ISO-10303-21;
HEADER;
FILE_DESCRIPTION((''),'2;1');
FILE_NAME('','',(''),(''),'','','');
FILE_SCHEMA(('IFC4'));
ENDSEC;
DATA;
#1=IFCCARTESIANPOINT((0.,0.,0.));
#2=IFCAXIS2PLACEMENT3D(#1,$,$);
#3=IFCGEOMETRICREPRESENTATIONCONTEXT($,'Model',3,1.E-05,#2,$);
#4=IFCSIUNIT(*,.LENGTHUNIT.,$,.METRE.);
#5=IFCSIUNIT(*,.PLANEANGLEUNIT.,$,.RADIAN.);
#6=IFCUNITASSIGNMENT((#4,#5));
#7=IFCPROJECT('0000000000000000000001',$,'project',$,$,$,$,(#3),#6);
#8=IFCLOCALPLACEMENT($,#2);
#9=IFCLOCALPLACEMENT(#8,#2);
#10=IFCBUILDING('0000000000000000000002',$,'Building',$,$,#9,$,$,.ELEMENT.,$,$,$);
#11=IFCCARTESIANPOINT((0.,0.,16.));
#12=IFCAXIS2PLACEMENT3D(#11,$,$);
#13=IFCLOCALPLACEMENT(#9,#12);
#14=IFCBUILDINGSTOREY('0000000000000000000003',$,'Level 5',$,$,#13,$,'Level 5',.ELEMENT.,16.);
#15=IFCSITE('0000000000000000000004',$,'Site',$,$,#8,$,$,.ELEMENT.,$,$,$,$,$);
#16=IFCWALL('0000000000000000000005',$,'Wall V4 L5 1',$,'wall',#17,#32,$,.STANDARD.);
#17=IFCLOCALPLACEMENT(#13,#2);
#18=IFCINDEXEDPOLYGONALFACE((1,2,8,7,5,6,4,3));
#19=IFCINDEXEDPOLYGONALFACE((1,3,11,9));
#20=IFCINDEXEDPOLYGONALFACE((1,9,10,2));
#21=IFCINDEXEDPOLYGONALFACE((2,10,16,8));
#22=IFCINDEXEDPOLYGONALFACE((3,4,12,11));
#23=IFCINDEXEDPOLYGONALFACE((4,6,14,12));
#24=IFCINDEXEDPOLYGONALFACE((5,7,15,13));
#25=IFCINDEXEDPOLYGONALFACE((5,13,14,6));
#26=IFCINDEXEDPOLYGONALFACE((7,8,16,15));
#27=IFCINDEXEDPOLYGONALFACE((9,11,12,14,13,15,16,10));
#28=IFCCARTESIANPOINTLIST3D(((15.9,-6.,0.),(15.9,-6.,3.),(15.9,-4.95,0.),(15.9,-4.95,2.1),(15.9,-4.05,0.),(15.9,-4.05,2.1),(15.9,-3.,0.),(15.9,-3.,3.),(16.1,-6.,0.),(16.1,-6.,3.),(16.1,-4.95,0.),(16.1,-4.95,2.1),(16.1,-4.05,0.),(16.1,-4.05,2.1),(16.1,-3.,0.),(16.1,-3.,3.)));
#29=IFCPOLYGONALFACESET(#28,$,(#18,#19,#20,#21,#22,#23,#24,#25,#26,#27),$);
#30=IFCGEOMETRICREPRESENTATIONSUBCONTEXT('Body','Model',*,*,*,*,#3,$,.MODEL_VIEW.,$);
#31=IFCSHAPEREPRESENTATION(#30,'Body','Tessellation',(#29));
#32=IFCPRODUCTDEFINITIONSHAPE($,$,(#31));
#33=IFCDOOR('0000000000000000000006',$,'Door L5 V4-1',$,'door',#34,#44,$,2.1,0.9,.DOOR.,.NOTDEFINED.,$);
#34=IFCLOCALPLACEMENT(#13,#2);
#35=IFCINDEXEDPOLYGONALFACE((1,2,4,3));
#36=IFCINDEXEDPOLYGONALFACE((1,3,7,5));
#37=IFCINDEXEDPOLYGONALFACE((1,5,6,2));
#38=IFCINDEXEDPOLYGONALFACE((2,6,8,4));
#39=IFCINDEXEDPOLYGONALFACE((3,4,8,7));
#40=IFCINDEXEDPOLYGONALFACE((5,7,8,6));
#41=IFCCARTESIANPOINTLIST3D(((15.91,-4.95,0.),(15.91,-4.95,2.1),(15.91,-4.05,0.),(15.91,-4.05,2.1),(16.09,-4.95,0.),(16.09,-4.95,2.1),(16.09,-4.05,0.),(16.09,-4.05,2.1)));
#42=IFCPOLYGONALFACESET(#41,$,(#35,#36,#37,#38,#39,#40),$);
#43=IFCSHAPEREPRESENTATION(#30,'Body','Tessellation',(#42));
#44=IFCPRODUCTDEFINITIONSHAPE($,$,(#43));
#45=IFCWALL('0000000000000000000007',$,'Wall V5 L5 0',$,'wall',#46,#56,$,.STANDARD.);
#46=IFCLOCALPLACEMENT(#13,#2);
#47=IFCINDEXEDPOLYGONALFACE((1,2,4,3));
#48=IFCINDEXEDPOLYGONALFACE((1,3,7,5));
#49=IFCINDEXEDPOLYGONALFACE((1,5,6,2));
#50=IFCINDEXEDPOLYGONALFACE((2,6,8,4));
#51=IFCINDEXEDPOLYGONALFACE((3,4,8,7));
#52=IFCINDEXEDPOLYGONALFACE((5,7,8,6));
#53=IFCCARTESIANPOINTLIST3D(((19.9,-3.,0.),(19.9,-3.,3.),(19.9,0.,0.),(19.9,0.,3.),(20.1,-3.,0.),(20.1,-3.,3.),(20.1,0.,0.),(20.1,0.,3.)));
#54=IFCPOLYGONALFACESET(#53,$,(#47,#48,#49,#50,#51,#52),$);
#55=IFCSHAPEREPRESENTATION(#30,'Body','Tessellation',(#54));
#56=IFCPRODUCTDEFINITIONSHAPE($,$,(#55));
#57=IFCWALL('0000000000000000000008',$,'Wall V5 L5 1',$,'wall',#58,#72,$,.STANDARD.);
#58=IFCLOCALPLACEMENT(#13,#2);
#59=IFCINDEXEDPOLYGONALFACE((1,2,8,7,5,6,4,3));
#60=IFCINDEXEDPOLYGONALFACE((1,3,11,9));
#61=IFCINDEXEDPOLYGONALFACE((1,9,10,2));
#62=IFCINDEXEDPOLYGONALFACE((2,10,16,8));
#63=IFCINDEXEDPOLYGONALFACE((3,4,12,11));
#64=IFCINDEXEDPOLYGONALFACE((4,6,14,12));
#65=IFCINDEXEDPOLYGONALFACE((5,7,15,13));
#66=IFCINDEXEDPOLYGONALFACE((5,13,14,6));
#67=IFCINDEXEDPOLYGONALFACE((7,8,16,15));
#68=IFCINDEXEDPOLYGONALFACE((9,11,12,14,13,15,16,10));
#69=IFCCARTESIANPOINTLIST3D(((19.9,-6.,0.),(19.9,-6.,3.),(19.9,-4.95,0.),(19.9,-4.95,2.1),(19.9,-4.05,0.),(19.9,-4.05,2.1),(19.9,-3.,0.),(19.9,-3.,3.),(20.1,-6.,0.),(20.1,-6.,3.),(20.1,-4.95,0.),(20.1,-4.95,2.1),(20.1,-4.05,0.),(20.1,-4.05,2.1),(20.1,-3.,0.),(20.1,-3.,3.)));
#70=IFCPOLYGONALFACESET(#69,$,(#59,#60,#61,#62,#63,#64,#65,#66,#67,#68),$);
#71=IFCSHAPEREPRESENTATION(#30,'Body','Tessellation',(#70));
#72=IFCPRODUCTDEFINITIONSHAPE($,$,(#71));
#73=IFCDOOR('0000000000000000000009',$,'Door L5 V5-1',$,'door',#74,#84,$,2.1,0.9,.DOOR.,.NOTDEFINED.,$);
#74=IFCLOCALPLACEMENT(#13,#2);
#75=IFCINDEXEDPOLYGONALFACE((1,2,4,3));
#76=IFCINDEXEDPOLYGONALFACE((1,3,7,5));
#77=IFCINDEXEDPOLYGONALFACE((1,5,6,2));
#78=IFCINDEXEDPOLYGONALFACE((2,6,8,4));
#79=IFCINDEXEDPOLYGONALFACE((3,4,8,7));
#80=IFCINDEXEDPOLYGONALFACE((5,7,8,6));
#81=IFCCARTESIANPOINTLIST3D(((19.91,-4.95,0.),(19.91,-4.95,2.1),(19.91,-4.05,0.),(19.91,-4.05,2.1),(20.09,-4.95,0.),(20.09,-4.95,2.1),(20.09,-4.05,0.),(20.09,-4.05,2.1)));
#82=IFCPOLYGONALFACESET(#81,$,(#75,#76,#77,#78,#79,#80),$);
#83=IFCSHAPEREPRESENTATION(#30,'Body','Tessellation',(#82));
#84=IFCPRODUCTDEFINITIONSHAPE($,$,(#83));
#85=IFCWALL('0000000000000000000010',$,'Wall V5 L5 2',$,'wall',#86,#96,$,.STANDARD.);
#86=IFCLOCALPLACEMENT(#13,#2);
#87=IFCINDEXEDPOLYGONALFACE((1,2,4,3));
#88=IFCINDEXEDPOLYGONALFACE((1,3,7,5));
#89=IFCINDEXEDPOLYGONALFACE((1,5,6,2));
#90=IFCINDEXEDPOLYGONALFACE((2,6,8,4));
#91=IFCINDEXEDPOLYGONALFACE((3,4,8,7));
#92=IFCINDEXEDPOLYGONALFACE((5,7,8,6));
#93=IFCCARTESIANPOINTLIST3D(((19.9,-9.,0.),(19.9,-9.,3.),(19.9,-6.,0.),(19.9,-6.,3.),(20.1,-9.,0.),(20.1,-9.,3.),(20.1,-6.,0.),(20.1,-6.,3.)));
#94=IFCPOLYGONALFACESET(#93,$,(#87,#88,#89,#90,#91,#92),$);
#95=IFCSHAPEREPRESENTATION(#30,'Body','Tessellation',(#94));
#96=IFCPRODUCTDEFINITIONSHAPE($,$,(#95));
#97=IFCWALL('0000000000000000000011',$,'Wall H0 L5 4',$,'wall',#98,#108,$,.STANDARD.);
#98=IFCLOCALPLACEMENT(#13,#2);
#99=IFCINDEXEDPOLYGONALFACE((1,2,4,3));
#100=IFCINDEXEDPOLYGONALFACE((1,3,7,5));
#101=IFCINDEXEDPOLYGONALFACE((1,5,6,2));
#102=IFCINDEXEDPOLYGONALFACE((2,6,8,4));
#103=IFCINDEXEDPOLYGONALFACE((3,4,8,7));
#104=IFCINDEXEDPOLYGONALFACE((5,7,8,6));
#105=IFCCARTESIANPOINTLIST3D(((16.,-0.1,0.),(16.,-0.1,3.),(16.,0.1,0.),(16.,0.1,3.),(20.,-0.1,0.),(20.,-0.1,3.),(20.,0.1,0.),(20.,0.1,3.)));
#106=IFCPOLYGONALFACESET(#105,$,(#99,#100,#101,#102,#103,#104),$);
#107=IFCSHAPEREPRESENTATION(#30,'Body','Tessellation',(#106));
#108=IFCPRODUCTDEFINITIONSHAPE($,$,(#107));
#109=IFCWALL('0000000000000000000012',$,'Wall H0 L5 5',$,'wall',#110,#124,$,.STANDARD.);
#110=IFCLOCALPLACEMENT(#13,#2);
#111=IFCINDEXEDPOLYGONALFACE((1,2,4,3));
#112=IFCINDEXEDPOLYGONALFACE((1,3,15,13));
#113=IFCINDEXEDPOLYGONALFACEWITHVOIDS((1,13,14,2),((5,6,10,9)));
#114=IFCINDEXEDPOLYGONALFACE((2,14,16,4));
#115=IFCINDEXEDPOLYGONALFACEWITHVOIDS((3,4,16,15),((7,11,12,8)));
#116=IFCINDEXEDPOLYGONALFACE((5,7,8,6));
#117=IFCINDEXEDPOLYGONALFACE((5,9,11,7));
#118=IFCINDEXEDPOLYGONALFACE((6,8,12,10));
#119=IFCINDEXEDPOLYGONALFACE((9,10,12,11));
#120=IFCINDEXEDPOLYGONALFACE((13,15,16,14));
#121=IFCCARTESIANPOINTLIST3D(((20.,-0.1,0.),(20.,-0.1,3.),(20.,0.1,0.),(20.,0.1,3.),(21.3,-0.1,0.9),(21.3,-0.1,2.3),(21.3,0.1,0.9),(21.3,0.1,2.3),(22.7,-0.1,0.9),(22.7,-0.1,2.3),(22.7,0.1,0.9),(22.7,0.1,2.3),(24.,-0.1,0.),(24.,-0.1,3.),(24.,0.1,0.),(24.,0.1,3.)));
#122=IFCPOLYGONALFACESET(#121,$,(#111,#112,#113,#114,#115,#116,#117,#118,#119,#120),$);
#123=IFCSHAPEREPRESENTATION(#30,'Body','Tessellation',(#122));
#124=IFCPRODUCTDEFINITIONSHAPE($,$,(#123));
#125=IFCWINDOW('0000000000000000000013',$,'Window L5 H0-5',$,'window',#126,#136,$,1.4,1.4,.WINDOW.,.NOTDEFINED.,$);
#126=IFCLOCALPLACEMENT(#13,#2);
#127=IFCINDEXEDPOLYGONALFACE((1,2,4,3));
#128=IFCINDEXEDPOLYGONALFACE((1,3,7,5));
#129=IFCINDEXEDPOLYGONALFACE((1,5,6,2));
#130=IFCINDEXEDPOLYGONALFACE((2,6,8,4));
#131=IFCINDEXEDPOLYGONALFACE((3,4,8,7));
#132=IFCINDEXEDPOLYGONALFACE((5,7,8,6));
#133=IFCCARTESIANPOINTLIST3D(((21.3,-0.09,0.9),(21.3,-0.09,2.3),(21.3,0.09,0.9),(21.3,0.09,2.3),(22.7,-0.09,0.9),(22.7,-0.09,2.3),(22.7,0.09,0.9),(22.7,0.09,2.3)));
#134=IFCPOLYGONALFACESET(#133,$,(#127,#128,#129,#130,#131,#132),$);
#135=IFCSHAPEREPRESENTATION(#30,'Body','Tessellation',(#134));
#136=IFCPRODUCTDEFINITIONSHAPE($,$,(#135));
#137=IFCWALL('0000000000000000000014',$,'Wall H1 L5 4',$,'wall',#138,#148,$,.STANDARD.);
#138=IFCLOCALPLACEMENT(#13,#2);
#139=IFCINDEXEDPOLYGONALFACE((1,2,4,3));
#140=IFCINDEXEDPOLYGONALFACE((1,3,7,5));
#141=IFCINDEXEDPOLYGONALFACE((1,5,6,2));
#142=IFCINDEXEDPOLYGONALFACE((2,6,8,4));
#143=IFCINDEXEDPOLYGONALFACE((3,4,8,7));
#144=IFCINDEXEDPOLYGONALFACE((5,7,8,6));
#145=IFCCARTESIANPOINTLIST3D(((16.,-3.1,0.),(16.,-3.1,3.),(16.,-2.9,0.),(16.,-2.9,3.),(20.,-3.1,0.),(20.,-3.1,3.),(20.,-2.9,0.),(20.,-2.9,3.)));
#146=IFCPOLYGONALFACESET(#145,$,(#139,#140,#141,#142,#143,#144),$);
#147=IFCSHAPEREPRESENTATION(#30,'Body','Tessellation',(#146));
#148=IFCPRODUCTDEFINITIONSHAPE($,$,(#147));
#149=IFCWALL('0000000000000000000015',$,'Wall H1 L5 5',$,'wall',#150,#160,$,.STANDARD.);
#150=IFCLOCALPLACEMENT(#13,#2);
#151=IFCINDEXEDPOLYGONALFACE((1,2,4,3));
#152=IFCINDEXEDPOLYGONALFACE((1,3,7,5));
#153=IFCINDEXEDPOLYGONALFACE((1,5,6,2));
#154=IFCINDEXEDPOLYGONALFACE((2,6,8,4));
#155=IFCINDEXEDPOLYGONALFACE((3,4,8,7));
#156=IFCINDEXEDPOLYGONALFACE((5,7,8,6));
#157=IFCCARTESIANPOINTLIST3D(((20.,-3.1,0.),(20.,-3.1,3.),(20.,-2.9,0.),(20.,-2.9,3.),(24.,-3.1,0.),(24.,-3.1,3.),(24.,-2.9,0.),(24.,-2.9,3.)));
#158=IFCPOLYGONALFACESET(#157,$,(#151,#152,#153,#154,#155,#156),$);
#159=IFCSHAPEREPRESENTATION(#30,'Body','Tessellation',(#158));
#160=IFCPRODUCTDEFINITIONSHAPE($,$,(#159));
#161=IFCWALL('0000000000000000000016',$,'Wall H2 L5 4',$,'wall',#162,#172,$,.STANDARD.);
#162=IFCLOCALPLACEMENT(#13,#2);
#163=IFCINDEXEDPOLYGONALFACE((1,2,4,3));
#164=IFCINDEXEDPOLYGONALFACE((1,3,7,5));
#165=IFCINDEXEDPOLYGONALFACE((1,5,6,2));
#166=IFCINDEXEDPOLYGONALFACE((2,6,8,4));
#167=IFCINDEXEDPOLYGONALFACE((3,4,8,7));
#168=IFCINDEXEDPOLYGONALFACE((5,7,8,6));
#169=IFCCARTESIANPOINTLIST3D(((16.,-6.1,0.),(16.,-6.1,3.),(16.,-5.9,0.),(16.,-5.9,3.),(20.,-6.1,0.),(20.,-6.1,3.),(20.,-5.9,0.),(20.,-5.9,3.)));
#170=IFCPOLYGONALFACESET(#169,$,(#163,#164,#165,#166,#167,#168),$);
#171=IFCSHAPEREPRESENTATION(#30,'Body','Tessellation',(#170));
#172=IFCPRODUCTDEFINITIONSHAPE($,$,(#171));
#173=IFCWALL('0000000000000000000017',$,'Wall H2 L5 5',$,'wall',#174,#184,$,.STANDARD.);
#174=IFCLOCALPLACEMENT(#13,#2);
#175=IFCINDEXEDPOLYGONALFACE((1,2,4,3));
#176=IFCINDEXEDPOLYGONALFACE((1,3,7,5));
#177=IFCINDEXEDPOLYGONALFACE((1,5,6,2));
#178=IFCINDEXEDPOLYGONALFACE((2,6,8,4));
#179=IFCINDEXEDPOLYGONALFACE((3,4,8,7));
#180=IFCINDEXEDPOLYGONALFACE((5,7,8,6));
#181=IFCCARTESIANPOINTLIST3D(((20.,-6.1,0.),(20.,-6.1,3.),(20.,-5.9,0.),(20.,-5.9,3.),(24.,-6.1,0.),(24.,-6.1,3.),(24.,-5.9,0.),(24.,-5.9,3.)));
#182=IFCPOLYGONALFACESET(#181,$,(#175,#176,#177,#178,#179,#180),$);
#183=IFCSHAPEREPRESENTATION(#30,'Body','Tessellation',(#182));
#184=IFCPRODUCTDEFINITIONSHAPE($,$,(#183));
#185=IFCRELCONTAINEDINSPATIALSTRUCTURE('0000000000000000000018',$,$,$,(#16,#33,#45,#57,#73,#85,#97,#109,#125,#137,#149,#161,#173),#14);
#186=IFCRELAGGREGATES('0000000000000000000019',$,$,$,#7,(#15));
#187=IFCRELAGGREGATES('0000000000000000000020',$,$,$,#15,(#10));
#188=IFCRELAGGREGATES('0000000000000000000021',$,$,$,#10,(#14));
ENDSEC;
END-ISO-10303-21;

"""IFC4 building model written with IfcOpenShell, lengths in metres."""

from ifc_helpers import new_model, si_unit, frame, frame_2d, origin, origin_2d, place, context, subcontext, project, spatial, rectangle, extrude, element, fill, save


model = new_model("IFC4")

# Units and contexts
model_context = context("Model", 3, precision=1e-05, world=origin())
body_context = subcontext(model_context, "Body", "Model", "MODEL_VIEW")
ifc_project = project(units=[si_unit("LENGTHUNIT", "METRE"), si_unit("PLANEANGLEUNIT", "RADIAN")], contexts=[model_context])

# Site, building, storey
site_placement = place(None, origin())
site = spatial("IfcSite", under=ifc_project, at=site_placement, Name="Site", CompositionType="ELEMENT")
building_placement = place(site_placement, origin())
building = spatial("IfcBuilding", under=site, at=building_placement, Name="Building", CompositionType="ELEMENT")
storey_placement = place(building_placement, frame((0.0, 0.0, 16.0)))
storey = spatial("IfcBuildingStorey", under=building, at=storey_placement, Name="Level 5", LongName="Level 5", CompositionType="ELEMENT", Elevation=16.0)

# Wall, opening, door
wall_1_placement = place(storey_placement, frame((16.0, -3.0, 0.0), z_axis=(0.0, 0.0, 1.0), x_axis=(0.0, -1.0, 0.0)))
wall_1 = element("IfcWall", 1, at=wall_1_placement, inside=storey, Name="Wall V4 L5 1", ObjectType="wall", PredefinedType="STANDARD", context=body_context, shape_type="SweptSolid", body=[
    extrude(rectangle(XDim=3.0, YDim=0.2, at=frame_2d((1.5, 0.0))), origin(), (0.0, 0.0, 1.0), 3.0),
])
opening_1_placement = place(storey_placement, frame((16.0, -4.5, 0.0), z_axis=(0.0, 0.0, 1.0), x_axis=(0.0, -1.0, 0.0)))
opening_1 = element("IfcOpeningElement", 2, at=opening_1_placement, cuts=wall_1, ObjectType="Opening", PredefinedType="OPENING", context=body_context, shape_type="SweptSolid", body=[
    extrude(rectangle(XDim=0.9, YDim=0.22, at=origin_2d()), origin(), (0.0, 0.0, 1.0), 2.1),
])
door_1_placement = place(storey_placement, frame((16.0, -4.5, 0.0), z_axis=(0.0, 0.0, 1.0), x_axis=(0.0, -1.0, 0.0)))
door_1 = element("IfcDoor", 3, at=door_1_placement, inside=storey, Name="Door L5 V4-1", ObjectType="door", OperationType="NOTDEFINED", OverallHeight=2.1, OverallWidth=0.9, PredefinedType="DOOR", context=body_context, shape_type="SweptSolid", body=[
    extrude(rectangle(XDim=0.9, YDim=0.18, at=origin_2d()), origin(), (0.0, 0.0, 1.0), 2.1),
])
fill(opening_1, door_1)

# Wall
wall_2_placement = place(storey_placement, frame((20.0, 0.0, 0.0), z_axis=(0.0, 0.0, 1.0), x_axis=(0.0, -1.0, 0.0)))
element("IfcWall", 4, at=wall_2_placement, inside=storey, Name="Wall V5 L5 0", ObjectType="wall", PredefinedType="STANDARD", context=body_context, shape_type="SweptSolid", body=[
    extrude(rectangle(XDim=3.0, YDim=0.2, at=frame_2d((1.5, 0.0))), origin(), (0.0, 0.0, 1.0), 3.0),
])

# Wall, opening, door
wall_3_placement = place(storey_placement, frame((20.0, -3.0, 0.0), z_axis=(0.0, 0.0, 1.0), x_axis=(0.0, -1.0, 0.0)))
wall_3 = element("IfcWall", 5, at=wall_3_placement, inside=storey, Name="Wall V5 L5 1", ObjectType="wall", PredefinedType="STANDARD", context=body_context, shape_type="SweptSolid", body=[
    extrude(rectangle(XDim=3.0, YDim=0.2, at=frame_2d((1.5, 0.0))), origin(), (0.0, 0.0, 1.0), 3.0),
])
opening_2_placement = place(storey_placement, frame((20.0, -4.5, 0.0), z_axis=(0.0, 0.0, 1.0), x_axis=(0.0, -1.0, 0.0)))
opening_2 = element("IfcOpeningElement", 6, at=opening_2_placement, cuts=wall_3, ObjectType="Opening", PredefinedType="OPENING", context=body_context, shape_type="SweptSolid", body=[
    extrude(rectangle(XDim=0.9, YDim=0.22, at=origin_2d()), origin(), (0.0, 0.0, 1.0), 2.1),
])
door_2_placement = place(storey_placement, frame((20.0, -4.5, 0.0), z_axis=(0.0, 0.0, 1.0), x_axis=(0.0, -1.0, 0.0)))
door_2 = element("IfcDoor", 7, at=door_2_placement, inside=storey, Name="Door L5 V5-1", ObjectType="door", OperationType="NOTDEFINED", OverallHeight=2.1, OverallWidth=0.9, PredefinedType="DOOR", context=body_context, shape_type="SweptSolid", body=[
    extrude(rectangle(XDim=0.9, YDim=0.18, at=origin_2d()), origin(), (0.0, 0.0, 1.0), 2.1),
])
fill(opening_2, door_2)

# Walls
wall_4_placement = place(storey_placement, frame((20.0, -6.0, 0.0), z_axis=(0.0, 0.0, 1.0), x_axis=(0.0, -1.0, 0.0)))
element("IfcWall", 8, at=wall_4_placement, inside=storey, Name="Wall V5 L5 2", ObjectType="wall", PredefinedType="STANDARD", context=body_context, shape_type="SweptSolid", body=[
    extrude(rectangle(XDim=3.0, YDim=0.2, at=frame_2d((1.5, 0.0))), origin(), (0.0, 0.0, 1.0), 3.0),
])
wall_5_placement = place(storey_placement, frame((16.0, 0.0, 0.0), z_axis=(0.0, 0.0, 1.0), x_axis=(1.0, 0.0, 0.0)))
element("IfcWall", 9, at=wall_5_placement, inside=storey, Name="Wall H0 L5 4", ObjectType="wall", PredefinedType="STANDARD", context=body_context, shape_type="SweptSolid", body=[
    extrude(rectangle(XDim=4.0, YDim=0.2, at=frame_2d((2.0, 0.0))), origin(), (0.0, 0.0, 1.0), 3.0),
])

# Wall, opening, window
wall_6_placement = place(storey_placement, frame((20.0, 0.0, 0.0), z_axis=(0.0, 0.0, 1.0), x_axis=(1.0, 0.0, 0.0)))
wall_6 = element("IfcWall", 10, at=wall_6_placement, inside=storey, Name="Wall H0 L5 5", ObjectType="wall", PredefinedType="STANDARD", context=body_context, shape_type="SweptSolid", body=[
    extrude(rectangle(XDim=4.0, YDim=0.2, at=frame_2d((2.0, 0.0))), origin(), (0.0, 0.0, 1.0), 3.0),
])
opening_3_placement = place(storey_placement, frame((22.0, 0.0, 0.9), z_axis=(0.0, 0.0, 1.0), x_axis=(1.0, 0.0, 0.0)))
opening_3 = element("IfcOpeningElement", 11, at=opening_3_placement, cuts=wall_6, ObjectType="Opening", PredefinedType="OPENING", context=body_context, shape_type="SweptSolid", body=[
    extrude(rectangle(XDim=1.4, YDim=0.22, at=origin_2d()), origin(), (0.0, 0.0, 1.0), 1.4),
])
window_placement = place(storey_placement, frame((22.0, 0.0, 0.9), z_axis=(0.0, 0.0, 1.0), x_axis=(1.0, 0.0, 0.0)))
window = element("IfcWindow", 12, at=window_placement, inside=storey, Name="Window L5 H0-5", ObjectType="window", OverallHeight=1.4, OverallWidth=1.4, PartitioningType="NOTDEFINED", PredefinedType="WINDOW", context=body_context, shape_type="SweptSolid", body=[
    extrude(rectangle(XDim=1.4, YDim=0.18, at=origin_2d()), origin(), (0.0, 0.0, 1.0), 1.4),
])
fill(opening_3, window)

# Walls
for number, where, z_axis, x_axis, name in (
    (13, (16.0, -3.0, 0.0), (0.0, 0.0, 1.0), (1.0, 0.0, 0.0), "Wall H1 L5 4"),
    (14, (20.0, -3.0, 0.0), (0.0, 0.0, 1.0), (1.0, 0.0, 0.0), "Wall H1 L5 5"),
    (15, (16.0, -6.0, 0.0), (0.0, 0.0, 1.0), (1.0, 0.0, 0.0), "Wall H2 L5 4"),
    (16, (20.0, -6.0, 0.0), (0.0, 0.0, 1.0), (1.0, 0.0, 0.0), "Wall H2 L5 5"),
):
    element("IfcWall", number, at=place(storey_placement, frame(where, z_axis=z_axis, x_axis=x_axis)), inside=storey, Name=name, ObjectType="wall", PredefinedType="STANDARD", context=body_context, shape_type="SweptSolid", body=[
        extrude(rectangle(XDim=4.0, YDim=0.2, at=frame_2d((2.0, 0.0))), origin(), (0.0, 0.0, 1.0), 3.0),
    ])

save(model, "model.ifc")
